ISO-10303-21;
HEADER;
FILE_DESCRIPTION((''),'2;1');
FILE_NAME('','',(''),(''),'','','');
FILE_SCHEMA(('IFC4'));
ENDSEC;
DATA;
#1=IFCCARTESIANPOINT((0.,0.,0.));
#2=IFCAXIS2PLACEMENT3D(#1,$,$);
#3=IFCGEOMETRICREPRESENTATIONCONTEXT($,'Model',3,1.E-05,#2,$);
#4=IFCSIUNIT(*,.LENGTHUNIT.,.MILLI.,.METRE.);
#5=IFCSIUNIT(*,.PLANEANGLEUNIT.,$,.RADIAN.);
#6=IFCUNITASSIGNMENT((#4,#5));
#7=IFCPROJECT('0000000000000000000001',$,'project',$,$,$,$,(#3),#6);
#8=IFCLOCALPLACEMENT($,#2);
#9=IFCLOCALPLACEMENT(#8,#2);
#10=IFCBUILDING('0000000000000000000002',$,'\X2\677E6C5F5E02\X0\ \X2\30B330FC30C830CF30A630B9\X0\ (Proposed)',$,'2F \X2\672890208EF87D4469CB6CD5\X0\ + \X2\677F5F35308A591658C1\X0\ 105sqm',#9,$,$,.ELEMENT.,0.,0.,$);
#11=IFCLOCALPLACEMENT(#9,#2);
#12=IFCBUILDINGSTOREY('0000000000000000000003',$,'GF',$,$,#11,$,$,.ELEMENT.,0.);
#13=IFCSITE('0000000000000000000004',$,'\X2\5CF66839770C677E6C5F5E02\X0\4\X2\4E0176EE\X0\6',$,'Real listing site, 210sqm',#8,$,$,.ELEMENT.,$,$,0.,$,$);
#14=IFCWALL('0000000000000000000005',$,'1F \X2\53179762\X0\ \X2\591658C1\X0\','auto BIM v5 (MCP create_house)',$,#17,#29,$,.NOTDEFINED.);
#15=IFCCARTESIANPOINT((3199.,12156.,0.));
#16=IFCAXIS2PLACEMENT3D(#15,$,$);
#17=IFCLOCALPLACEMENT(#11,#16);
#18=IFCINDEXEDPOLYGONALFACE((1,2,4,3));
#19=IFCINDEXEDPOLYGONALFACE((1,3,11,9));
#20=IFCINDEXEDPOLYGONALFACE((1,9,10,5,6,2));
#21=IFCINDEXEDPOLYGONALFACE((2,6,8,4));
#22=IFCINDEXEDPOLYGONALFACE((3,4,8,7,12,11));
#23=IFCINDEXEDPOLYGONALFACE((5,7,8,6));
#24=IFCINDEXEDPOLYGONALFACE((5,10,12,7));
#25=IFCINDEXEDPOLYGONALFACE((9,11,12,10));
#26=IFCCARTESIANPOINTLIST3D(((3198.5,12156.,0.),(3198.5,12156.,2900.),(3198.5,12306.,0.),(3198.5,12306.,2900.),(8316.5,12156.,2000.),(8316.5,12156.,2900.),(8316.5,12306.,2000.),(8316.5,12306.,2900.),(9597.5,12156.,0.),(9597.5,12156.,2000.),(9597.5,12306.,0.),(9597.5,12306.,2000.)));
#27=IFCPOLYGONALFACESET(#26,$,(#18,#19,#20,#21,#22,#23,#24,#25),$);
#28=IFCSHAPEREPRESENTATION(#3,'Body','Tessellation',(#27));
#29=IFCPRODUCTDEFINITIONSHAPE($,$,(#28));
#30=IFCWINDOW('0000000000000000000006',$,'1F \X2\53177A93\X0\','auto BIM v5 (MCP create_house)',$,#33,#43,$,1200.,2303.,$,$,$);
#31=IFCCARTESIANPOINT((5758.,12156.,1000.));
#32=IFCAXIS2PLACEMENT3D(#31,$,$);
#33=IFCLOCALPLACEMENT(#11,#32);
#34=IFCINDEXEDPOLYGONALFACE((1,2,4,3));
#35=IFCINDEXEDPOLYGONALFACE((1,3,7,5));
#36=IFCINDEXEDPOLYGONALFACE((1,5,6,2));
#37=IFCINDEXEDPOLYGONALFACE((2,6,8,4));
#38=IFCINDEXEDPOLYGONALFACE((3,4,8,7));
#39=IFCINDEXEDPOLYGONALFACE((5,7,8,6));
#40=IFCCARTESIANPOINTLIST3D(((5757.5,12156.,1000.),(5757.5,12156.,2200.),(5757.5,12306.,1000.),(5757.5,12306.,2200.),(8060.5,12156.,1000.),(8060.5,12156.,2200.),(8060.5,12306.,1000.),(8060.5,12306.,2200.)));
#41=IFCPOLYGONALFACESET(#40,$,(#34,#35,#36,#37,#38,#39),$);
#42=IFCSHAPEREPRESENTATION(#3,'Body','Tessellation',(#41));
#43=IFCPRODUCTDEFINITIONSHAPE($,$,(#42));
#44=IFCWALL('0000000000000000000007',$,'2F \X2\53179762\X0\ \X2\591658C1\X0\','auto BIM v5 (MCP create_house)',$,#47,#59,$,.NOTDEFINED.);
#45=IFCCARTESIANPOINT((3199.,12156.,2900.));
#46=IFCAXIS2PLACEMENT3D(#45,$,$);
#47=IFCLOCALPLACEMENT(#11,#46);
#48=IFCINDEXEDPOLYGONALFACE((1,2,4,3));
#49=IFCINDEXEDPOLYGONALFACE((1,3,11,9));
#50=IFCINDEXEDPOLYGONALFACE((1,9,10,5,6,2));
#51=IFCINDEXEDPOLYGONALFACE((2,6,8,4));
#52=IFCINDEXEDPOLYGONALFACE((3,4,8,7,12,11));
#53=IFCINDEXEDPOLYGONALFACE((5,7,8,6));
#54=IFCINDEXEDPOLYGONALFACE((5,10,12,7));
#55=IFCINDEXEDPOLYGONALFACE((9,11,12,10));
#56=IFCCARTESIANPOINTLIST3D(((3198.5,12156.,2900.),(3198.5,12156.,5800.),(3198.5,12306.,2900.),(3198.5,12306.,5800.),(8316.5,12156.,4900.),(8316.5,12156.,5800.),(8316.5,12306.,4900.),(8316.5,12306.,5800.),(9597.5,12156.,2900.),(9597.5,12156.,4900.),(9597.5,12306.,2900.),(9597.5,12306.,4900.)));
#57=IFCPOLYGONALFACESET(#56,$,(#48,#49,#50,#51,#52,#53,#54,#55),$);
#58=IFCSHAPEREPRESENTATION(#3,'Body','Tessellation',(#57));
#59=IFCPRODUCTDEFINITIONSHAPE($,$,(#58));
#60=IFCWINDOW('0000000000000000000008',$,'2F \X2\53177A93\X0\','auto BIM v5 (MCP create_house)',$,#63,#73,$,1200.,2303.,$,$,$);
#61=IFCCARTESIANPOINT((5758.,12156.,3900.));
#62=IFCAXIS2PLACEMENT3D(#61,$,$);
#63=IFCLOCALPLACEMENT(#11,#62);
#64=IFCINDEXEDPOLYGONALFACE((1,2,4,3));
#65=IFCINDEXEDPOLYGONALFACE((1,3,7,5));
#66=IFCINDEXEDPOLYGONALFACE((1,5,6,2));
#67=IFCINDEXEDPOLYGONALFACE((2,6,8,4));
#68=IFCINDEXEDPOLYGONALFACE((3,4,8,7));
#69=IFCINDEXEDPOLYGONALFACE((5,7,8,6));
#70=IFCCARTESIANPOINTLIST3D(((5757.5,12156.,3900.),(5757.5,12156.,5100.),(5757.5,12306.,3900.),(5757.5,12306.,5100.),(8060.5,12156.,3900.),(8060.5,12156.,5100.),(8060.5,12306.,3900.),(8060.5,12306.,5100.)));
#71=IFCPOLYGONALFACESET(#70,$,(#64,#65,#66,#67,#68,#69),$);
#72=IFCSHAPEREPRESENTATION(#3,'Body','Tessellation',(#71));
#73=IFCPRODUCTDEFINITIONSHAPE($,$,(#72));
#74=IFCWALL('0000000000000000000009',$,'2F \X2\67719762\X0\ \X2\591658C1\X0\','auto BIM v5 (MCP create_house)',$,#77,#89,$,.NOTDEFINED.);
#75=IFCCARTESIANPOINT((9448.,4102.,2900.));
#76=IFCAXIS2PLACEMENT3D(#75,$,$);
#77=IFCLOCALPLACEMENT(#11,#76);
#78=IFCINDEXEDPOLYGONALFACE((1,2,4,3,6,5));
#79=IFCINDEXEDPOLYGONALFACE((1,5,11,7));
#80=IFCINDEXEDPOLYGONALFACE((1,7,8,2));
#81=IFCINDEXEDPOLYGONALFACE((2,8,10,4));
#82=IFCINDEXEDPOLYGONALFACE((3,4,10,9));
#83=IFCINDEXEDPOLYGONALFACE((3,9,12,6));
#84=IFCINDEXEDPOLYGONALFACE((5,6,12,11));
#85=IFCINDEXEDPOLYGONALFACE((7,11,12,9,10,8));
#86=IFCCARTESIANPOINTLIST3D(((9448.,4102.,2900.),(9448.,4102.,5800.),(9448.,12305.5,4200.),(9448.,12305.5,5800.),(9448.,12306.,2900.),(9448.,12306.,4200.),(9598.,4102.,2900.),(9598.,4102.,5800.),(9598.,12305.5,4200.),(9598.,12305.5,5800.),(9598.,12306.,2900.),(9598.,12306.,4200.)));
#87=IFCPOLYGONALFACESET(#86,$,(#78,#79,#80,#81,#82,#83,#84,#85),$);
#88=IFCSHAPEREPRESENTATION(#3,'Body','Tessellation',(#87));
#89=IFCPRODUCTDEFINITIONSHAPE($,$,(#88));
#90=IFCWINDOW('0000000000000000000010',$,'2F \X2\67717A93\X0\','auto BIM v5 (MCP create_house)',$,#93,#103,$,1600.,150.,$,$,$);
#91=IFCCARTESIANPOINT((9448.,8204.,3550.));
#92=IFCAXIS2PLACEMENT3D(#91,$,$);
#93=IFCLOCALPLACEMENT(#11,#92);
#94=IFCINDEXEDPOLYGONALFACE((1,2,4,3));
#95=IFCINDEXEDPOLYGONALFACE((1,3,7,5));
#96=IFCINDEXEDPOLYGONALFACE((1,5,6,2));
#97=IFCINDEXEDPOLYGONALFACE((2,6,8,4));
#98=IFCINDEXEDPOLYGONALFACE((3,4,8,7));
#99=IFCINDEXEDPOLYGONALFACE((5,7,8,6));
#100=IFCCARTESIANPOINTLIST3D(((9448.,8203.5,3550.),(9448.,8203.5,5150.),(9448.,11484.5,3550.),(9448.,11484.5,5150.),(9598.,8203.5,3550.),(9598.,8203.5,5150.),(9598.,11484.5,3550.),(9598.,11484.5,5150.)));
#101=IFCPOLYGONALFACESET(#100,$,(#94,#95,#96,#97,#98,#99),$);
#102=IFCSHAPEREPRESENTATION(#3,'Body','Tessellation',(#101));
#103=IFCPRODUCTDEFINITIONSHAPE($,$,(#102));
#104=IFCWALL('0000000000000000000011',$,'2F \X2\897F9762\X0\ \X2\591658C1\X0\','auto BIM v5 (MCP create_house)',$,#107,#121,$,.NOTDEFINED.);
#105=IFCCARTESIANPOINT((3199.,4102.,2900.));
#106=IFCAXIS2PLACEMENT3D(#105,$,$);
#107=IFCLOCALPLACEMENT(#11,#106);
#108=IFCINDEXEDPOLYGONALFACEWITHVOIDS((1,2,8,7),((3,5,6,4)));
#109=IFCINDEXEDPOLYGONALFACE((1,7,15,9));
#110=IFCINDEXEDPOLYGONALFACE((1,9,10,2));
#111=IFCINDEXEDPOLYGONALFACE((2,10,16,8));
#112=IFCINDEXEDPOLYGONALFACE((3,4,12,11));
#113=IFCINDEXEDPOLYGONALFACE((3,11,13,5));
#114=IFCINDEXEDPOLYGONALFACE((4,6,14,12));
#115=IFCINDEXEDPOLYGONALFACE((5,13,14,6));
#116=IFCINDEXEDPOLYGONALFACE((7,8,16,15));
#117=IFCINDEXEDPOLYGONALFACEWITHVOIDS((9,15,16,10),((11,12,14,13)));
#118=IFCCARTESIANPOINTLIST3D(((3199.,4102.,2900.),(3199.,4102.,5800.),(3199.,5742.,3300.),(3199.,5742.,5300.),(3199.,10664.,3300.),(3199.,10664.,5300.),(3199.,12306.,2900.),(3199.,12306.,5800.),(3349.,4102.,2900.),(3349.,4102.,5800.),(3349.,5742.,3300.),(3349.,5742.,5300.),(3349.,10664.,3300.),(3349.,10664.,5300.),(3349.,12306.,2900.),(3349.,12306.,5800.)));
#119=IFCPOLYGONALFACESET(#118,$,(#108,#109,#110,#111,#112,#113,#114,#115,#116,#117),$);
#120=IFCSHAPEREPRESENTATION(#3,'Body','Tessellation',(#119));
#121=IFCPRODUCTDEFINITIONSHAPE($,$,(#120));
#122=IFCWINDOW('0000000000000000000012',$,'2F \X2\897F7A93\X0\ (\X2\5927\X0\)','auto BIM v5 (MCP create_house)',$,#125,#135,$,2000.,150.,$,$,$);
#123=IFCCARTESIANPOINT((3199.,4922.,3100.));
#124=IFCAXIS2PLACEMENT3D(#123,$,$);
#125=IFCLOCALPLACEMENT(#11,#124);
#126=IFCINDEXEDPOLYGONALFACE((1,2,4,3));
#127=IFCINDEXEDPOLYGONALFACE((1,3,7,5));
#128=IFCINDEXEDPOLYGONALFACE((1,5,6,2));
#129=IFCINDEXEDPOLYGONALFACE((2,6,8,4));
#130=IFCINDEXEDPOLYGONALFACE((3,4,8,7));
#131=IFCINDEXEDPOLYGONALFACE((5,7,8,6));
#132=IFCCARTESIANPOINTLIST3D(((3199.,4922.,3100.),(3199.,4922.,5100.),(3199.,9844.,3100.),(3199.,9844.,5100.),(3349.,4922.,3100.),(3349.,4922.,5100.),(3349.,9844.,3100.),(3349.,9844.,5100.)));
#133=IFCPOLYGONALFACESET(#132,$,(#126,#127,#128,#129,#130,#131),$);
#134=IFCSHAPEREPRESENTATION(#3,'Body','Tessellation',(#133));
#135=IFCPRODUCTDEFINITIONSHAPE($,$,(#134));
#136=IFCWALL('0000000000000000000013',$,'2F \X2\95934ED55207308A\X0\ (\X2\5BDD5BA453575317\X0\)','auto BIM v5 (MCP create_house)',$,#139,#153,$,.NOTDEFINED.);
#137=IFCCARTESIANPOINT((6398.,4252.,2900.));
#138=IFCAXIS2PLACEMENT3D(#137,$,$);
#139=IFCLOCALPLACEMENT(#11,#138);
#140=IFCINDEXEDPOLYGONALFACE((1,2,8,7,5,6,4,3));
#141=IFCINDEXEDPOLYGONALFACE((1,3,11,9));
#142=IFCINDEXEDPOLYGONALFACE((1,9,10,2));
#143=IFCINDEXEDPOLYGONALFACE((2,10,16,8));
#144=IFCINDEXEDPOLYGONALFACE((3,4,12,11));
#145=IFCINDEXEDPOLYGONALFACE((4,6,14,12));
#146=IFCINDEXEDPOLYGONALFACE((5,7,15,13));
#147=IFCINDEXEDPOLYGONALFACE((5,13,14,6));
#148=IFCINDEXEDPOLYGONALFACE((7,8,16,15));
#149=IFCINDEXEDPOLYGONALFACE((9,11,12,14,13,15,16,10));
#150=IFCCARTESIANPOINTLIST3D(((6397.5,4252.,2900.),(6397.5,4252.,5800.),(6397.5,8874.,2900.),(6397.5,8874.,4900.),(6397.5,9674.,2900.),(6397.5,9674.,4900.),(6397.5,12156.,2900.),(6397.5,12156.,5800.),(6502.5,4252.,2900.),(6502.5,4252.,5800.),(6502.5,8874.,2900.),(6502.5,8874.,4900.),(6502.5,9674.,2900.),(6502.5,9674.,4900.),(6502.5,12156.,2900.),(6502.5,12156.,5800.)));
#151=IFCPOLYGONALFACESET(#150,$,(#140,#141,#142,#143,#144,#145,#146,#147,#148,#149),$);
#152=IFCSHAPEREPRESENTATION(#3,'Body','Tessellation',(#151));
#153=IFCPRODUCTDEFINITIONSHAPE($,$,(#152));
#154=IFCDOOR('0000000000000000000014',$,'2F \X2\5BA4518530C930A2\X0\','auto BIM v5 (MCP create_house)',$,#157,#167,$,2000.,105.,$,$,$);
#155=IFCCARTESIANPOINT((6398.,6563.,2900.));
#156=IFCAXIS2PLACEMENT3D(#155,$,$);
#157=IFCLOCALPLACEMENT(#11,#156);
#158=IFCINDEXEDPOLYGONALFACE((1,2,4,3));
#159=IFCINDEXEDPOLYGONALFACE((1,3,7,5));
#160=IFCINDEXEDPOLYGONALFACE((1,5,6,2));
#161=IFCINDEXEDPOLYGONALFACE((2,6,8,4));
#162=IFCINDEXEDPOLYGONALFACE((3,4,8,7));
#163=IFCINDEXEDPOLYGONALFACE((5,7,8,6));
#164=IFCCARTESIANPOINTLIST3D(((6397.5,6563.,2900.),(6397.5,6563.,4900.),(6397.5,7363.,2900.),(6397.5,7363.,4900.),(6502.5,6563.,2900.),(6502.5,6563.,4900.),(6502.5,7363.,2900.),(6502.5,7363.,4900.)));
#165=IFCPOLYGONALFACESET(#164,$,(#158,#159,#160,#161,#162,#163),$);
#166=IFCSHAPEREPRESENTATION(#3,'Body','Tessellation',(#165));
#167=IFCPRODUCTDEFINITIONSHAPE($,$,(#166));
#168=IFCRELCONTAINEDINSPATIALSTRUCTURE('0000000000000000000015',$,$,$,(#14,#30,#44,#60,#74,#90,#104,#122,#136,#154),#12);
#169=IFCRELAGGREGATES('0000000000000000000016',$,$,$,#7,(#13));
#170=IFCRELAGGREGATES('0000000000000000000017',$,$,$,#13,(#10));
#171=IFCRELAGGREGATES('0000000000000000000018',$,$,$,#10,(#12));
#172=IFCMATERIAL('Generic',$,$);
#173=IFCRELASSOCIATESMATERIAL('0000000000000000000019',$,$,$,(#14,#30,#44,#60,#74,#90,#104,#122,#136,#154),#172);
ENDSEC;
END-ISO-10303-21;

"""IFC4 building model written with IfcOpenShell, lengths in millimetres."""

from ifc_helpers import new_model, si_unit, frame, frame_2d, origin, place, context, project, spatial, rectangle, extrude, material, element, fill, save


model = new_model("IFC4")

# Units and contexts
model_context = context("Model", 3, precision=1e-05, world=origin())
ifc_project = project(units=[si_unit("LENGTHUNIT", "METRE", prefix="MILLI"), si_unit("PLANEANGLEUNIT", "RADIAN")], contexts=[model_context])

# Site, building, storey
site_placement = place(None, origin())
site = spatial("IfcSite", under=ifc_project, at=site_placement, Name="島根県松江市4丁目6", ObjectType="Real listing site, 210sqm", CompositionType="ELEMENT", RefElevation=0.0)
building_placement = place(site_placement, origin())
building = spatial("IfcBuilding", under=site, at=building_placement, Name="松江市 コートハウス (Proposed)", ObjectType="2F 木造軸組構法 + 板張り外壁 105sqm", CompositionType="ELEMENT", ElevationOfRefHeight=0.0, ElevationOfTerrain=0.0)
storey_placement = place(building_placement, origin())
storey = spatial("IfcBuildingStorey", under=building, at=storey_placement, Name="GF", CompositionType="ELEMENT", Elevation=0.0)

# Wall, opening, window
ifc_material = material(Name="Generic")
wall_1_placement = place(storey_placement, frame((3199.0, 12156.0, 0.0)))
wall_1 = element("IfcWall", 1, at=wall_1_placement, inside=storey, material=ifc_material, Name="1F 北面 外壁", Description="auto BIM v5 (MCP create_house)", PredefinedType="NOTDEFINED", context=model_context, shape_type="SweptSolid", body=[
    extrude(rectangle(XDim=6399.0, YDim=150.0, at=frame_2d((3199.0, 75.0))), frame((3199.0, 12156.0, 0.0)), (0.0, 0.0, 1.0), 2900.0),
])
opening_1_placement = place(storey_placement, frame((5758.0, 12156.0, 1000.0)))
opening_1 = element("IfcOpeningElement", 2, at=opening_1_placement, cuts=wall_1, PredefinedType="NOTDEFINED", context=model_context, shape_type="SweptSolid", body=[
    extrude(rectangle(XDim=2303.0, YDim=150.0, at=frame_2d((1151.0, 75.0))), frame((5758.0, 12156.0, 1000.0)), (0.0, 0.0, 1.0), 1200.0),
])
window_1_placement = place(storey_placement, frame((5758.0, 12156.0, 1000.0)))
window_1 = element("IfcWindow", 3, at=window_1_placement, inside=storey, material=ifc_material, Name="1F 北窓", Description="auto BIM v5 (MCP create_house)", OverallHeight=1200.0, OverallWidth=2303.0, context=model_context, shape_type="SweptSolid", body=[
    extrude(rectangle(XDim=2303.0, YDim=150.0, at=frame_2d((1151.0, 75.0))), frame((5758.0, 12156.0, 1000.0)), (0.0, 0.0, 1.0), 1200.0),
])
fill(opening_1, window_1)

# Walls, openings, windows
wall_2_placement = place(storey_placement, frame((3199.0, 12156.0, 2900.0)))
wall_2 = element("IfcWall", 4, at=wall_2_placement, inside=storey, material=ifc_material, Name="2F 北面 外壁", Description="auto BIM v5 (MCP create_house)", PredefinedType="NOTDEFINED", context=model_context, shape_type="SweptSolid", body=[
    extrude(rectangle(XDim=6399.0, YDim=150.0, at=frame_2d((3199.0, 75.0))), frame((3199.0, 12156.0, 2900.0)), (0.0, 0.0, 1.0), 2900.0),
])
opening_2_placement = place(storey_placement, frame((5758.0, 12156.0, 3900.0)))
opening_2 = element("IfcOpeningElement", 5, at=opening_2_placement, cuts=wall_2, PredefinedType="NOTDEFINED", context=model_context, shape_type="SweptSolid", body=[
    extrude(rectangle(XDim=2303.0, YDim=150.0, at=frame_2d((1151.0, 75.0))), frame((5758.0, 12156.0, 3900.0)), (0.0, 0.0, 1.0), 1200.0),
])
window_2_placement = place(storey_placement, frame((5758.0, 12156.0, 3900.0)))
window_2 = element("IfcWindow", 6, at=window_2_placement, inside=storey, material=ifc_material, Name="2F 北窓", Description="auto BIM v5 (MCP create_house)", OverallHeight=1200.0, OverallWidth=2303.0, context=model_context, shape_type="SweptSolid", body=[
    extrude(rectangle(XDim=2303.0, YDim=150.0, at=frame_2d((1151.0, 75.0))), frame((5758.0, 12156.0, 3900.0)), (0.0, 0.0, 1.0), 1200.0),
])
fill(opening_2, window_2)
wall_3_placement = place(storey_placement, frame((9448.0, 4102.0, 2900.0)))
wall_3 = element("IfcWall", 7, at=wall_3_placement, inside=storey, material=ifc_material, Name="2F 東面 外壁", Description="auto BIM v5 (MCP create_house)", PredefinedType="NOTDEFINED", context=model_context, shape_type="SweptSolid", body=[
    extrude(rectangle(XDim=150.0, YDim=8204.0, at=frame_2d((75.0, 4102.0))), frame((9448.0, 4102.0, 2900.0)), (0.0, 0.0, 1.0), 2900.0),
])
opening_3_placement = place(storey_placement, frame((9448.0, 8204.0, 3550.0)))
opening_3 = element("IfcOpeningElement", 8, at=opening_3_placement, cuts=wall_3, PredefinedType="NOTDEFINED", context=model_context, shape_type="SweptSolid", body=[
    extrude(rectangle(XDim=150.0, YDim=3281.0, at=frame_2d((75.0, 1640.0))), frame((9448.0, 8204.0, 3550.0)), (0.0, 0.0, 1.0), 1600.0),
])
window_3_placement = place(storey_placement, frame((9448.0, 8204.0, 3550.0)))
window_3 = element("IfcWindow", 9, at=window_3_placement, inside=storey, material=ifc_material, Name="2F 東窓", Description="auto BIM v5 (MCP create_house)", OverallHeight=1600.0, OverallWidth=150.0, context=model_context, shape_type="SweptSolid", body=[
    extrude(rectangle(XDim=150.0, YDim=3281.0, at=frame_2d((75.0, 1640.0))), frame((9448.0, 8204.0, 3550.0)), (0.0, 0.0, 1.0), 1600.0),
])
fill(opening_3, window_3)
wall_4_placement = place(storey_placement, frame((3199.0, 4102.0, 2900.0)))
wall_4 = element("IfcWall", 10, at=wall_4_placement, inside=storey, material=ifc_material, Name="2F 西面 外壁", Description="auto BIM v5 (MCP create_house)", PredefinedType="NOTDEFINED", context=model_context, shape_type="SweptSolid", body=[
    extrude(rectangle(XDim=150.0, YDim=8204.0, at=frame_2d((75.0, 4102.0))), frame((3199.0, 4102.0, 2900.0)), (0.0, 0.0, 1.0), 2900.0),
])
opening_4_placement = place(storey_placement, frame((3199.0, 4922.0, 3100.0)))
opening_4 = element("IfcOpeningElement", 11, at=opening_4_placement, cuts=wall_4, PredefinedType="NOTDEFINED", context=model_context, shape_type="SweptSolid", body=[
    extrude(rectangle(XDim=150.0, YDim=4922.0, at=frame_2d((75.0, 2461.0))), frame((3199.0, 4922.0, 3100.0)), (0.0, 0.0, 1.0), 2000.0),
])
window_4_placement = place(storey_placement, frame((3199.0, 4922.0, 3100.0)))
window_4 = element("IfcWindow", 12, at=window_4_placement, inside=storey, material=ifc_material, Name="2F 西窓 (大)", Description="auto BIM v5 (MCP create_house)", OverallHeight=2000.0, OverallWidth=150.0, context=model_context, shape_type="SweptSolid", body=[
    extrude(rectangle(XDim=150.0, YDim=4922.0, at=frame_2d((75.0, 2461.0))), frame((3199.0, 4922.0, 3100.0)), (0.0, 0.0, 1.0), 2000.0),
])
fill(opening_4, window_4)

# Wall, opening, door
wall_5_placement = place(storey_placement, frame((6398.0, 4252.0, 2900.0)))
wall_5 = element("IfcWall", 13, at=wall_5_placement, inside=storey, material=ifc_material, Name="2F 間仕切り (寝室南北)", Description="auto BIM v5 (MCP create_house)", PredefinedType="NOTDEFINED", context=model_context, shape_type="SweptSolid", body=[
    extrude(rectangle(XDim=105.0, YDim=7904.0, at=frame_2d((52.0, 3952.0))), frame((6398.0, 4252.0, 2900.0)), (0.0, 0.0, 1.0), 2900.0),
])
opening_5_placement = place(storey_placement, frame((6398.0, 6563.0, 2900.0)))
opening_5 = element("IfcOpeningElement", 14, at=opening_5_placement, cuts=wall_5, PredefinedType="NOTDEFINED", context=model_context, shape_type="SweptSolid", body=[
    extrude(rectangle(XDim=105.0, YDim=800.0, at=frame_2d((52.0, 400.0))), frame((6398.0, 6563.0, 2900.0)), (0.0, 0.0, 1.0), 2000.0),
])
door_placement = place(storey_placement, frame((6398.0, 6563.0, 2900.0)))
door = element("IfcDoor", 15, at=door_placement, inside=storey, material=ifc_material, Name="2F 室内ドア", Description="auto BIM v5 (MCP create_house)", OverallHeight=2000.0, OverallWidth=105.0, context=model_context, shape_type="SweptSolid", body=[
    extrude(rectangle(XDim=105.0, YDim=800.0, at=frame_2d((52.0, 400.0))), frame((6398.0, 6563.0, 2900.0)), (0.0, 0.0, 1.0), 2000.0),
])
fill(opening_5, door)

save(model, "model.ifc")
